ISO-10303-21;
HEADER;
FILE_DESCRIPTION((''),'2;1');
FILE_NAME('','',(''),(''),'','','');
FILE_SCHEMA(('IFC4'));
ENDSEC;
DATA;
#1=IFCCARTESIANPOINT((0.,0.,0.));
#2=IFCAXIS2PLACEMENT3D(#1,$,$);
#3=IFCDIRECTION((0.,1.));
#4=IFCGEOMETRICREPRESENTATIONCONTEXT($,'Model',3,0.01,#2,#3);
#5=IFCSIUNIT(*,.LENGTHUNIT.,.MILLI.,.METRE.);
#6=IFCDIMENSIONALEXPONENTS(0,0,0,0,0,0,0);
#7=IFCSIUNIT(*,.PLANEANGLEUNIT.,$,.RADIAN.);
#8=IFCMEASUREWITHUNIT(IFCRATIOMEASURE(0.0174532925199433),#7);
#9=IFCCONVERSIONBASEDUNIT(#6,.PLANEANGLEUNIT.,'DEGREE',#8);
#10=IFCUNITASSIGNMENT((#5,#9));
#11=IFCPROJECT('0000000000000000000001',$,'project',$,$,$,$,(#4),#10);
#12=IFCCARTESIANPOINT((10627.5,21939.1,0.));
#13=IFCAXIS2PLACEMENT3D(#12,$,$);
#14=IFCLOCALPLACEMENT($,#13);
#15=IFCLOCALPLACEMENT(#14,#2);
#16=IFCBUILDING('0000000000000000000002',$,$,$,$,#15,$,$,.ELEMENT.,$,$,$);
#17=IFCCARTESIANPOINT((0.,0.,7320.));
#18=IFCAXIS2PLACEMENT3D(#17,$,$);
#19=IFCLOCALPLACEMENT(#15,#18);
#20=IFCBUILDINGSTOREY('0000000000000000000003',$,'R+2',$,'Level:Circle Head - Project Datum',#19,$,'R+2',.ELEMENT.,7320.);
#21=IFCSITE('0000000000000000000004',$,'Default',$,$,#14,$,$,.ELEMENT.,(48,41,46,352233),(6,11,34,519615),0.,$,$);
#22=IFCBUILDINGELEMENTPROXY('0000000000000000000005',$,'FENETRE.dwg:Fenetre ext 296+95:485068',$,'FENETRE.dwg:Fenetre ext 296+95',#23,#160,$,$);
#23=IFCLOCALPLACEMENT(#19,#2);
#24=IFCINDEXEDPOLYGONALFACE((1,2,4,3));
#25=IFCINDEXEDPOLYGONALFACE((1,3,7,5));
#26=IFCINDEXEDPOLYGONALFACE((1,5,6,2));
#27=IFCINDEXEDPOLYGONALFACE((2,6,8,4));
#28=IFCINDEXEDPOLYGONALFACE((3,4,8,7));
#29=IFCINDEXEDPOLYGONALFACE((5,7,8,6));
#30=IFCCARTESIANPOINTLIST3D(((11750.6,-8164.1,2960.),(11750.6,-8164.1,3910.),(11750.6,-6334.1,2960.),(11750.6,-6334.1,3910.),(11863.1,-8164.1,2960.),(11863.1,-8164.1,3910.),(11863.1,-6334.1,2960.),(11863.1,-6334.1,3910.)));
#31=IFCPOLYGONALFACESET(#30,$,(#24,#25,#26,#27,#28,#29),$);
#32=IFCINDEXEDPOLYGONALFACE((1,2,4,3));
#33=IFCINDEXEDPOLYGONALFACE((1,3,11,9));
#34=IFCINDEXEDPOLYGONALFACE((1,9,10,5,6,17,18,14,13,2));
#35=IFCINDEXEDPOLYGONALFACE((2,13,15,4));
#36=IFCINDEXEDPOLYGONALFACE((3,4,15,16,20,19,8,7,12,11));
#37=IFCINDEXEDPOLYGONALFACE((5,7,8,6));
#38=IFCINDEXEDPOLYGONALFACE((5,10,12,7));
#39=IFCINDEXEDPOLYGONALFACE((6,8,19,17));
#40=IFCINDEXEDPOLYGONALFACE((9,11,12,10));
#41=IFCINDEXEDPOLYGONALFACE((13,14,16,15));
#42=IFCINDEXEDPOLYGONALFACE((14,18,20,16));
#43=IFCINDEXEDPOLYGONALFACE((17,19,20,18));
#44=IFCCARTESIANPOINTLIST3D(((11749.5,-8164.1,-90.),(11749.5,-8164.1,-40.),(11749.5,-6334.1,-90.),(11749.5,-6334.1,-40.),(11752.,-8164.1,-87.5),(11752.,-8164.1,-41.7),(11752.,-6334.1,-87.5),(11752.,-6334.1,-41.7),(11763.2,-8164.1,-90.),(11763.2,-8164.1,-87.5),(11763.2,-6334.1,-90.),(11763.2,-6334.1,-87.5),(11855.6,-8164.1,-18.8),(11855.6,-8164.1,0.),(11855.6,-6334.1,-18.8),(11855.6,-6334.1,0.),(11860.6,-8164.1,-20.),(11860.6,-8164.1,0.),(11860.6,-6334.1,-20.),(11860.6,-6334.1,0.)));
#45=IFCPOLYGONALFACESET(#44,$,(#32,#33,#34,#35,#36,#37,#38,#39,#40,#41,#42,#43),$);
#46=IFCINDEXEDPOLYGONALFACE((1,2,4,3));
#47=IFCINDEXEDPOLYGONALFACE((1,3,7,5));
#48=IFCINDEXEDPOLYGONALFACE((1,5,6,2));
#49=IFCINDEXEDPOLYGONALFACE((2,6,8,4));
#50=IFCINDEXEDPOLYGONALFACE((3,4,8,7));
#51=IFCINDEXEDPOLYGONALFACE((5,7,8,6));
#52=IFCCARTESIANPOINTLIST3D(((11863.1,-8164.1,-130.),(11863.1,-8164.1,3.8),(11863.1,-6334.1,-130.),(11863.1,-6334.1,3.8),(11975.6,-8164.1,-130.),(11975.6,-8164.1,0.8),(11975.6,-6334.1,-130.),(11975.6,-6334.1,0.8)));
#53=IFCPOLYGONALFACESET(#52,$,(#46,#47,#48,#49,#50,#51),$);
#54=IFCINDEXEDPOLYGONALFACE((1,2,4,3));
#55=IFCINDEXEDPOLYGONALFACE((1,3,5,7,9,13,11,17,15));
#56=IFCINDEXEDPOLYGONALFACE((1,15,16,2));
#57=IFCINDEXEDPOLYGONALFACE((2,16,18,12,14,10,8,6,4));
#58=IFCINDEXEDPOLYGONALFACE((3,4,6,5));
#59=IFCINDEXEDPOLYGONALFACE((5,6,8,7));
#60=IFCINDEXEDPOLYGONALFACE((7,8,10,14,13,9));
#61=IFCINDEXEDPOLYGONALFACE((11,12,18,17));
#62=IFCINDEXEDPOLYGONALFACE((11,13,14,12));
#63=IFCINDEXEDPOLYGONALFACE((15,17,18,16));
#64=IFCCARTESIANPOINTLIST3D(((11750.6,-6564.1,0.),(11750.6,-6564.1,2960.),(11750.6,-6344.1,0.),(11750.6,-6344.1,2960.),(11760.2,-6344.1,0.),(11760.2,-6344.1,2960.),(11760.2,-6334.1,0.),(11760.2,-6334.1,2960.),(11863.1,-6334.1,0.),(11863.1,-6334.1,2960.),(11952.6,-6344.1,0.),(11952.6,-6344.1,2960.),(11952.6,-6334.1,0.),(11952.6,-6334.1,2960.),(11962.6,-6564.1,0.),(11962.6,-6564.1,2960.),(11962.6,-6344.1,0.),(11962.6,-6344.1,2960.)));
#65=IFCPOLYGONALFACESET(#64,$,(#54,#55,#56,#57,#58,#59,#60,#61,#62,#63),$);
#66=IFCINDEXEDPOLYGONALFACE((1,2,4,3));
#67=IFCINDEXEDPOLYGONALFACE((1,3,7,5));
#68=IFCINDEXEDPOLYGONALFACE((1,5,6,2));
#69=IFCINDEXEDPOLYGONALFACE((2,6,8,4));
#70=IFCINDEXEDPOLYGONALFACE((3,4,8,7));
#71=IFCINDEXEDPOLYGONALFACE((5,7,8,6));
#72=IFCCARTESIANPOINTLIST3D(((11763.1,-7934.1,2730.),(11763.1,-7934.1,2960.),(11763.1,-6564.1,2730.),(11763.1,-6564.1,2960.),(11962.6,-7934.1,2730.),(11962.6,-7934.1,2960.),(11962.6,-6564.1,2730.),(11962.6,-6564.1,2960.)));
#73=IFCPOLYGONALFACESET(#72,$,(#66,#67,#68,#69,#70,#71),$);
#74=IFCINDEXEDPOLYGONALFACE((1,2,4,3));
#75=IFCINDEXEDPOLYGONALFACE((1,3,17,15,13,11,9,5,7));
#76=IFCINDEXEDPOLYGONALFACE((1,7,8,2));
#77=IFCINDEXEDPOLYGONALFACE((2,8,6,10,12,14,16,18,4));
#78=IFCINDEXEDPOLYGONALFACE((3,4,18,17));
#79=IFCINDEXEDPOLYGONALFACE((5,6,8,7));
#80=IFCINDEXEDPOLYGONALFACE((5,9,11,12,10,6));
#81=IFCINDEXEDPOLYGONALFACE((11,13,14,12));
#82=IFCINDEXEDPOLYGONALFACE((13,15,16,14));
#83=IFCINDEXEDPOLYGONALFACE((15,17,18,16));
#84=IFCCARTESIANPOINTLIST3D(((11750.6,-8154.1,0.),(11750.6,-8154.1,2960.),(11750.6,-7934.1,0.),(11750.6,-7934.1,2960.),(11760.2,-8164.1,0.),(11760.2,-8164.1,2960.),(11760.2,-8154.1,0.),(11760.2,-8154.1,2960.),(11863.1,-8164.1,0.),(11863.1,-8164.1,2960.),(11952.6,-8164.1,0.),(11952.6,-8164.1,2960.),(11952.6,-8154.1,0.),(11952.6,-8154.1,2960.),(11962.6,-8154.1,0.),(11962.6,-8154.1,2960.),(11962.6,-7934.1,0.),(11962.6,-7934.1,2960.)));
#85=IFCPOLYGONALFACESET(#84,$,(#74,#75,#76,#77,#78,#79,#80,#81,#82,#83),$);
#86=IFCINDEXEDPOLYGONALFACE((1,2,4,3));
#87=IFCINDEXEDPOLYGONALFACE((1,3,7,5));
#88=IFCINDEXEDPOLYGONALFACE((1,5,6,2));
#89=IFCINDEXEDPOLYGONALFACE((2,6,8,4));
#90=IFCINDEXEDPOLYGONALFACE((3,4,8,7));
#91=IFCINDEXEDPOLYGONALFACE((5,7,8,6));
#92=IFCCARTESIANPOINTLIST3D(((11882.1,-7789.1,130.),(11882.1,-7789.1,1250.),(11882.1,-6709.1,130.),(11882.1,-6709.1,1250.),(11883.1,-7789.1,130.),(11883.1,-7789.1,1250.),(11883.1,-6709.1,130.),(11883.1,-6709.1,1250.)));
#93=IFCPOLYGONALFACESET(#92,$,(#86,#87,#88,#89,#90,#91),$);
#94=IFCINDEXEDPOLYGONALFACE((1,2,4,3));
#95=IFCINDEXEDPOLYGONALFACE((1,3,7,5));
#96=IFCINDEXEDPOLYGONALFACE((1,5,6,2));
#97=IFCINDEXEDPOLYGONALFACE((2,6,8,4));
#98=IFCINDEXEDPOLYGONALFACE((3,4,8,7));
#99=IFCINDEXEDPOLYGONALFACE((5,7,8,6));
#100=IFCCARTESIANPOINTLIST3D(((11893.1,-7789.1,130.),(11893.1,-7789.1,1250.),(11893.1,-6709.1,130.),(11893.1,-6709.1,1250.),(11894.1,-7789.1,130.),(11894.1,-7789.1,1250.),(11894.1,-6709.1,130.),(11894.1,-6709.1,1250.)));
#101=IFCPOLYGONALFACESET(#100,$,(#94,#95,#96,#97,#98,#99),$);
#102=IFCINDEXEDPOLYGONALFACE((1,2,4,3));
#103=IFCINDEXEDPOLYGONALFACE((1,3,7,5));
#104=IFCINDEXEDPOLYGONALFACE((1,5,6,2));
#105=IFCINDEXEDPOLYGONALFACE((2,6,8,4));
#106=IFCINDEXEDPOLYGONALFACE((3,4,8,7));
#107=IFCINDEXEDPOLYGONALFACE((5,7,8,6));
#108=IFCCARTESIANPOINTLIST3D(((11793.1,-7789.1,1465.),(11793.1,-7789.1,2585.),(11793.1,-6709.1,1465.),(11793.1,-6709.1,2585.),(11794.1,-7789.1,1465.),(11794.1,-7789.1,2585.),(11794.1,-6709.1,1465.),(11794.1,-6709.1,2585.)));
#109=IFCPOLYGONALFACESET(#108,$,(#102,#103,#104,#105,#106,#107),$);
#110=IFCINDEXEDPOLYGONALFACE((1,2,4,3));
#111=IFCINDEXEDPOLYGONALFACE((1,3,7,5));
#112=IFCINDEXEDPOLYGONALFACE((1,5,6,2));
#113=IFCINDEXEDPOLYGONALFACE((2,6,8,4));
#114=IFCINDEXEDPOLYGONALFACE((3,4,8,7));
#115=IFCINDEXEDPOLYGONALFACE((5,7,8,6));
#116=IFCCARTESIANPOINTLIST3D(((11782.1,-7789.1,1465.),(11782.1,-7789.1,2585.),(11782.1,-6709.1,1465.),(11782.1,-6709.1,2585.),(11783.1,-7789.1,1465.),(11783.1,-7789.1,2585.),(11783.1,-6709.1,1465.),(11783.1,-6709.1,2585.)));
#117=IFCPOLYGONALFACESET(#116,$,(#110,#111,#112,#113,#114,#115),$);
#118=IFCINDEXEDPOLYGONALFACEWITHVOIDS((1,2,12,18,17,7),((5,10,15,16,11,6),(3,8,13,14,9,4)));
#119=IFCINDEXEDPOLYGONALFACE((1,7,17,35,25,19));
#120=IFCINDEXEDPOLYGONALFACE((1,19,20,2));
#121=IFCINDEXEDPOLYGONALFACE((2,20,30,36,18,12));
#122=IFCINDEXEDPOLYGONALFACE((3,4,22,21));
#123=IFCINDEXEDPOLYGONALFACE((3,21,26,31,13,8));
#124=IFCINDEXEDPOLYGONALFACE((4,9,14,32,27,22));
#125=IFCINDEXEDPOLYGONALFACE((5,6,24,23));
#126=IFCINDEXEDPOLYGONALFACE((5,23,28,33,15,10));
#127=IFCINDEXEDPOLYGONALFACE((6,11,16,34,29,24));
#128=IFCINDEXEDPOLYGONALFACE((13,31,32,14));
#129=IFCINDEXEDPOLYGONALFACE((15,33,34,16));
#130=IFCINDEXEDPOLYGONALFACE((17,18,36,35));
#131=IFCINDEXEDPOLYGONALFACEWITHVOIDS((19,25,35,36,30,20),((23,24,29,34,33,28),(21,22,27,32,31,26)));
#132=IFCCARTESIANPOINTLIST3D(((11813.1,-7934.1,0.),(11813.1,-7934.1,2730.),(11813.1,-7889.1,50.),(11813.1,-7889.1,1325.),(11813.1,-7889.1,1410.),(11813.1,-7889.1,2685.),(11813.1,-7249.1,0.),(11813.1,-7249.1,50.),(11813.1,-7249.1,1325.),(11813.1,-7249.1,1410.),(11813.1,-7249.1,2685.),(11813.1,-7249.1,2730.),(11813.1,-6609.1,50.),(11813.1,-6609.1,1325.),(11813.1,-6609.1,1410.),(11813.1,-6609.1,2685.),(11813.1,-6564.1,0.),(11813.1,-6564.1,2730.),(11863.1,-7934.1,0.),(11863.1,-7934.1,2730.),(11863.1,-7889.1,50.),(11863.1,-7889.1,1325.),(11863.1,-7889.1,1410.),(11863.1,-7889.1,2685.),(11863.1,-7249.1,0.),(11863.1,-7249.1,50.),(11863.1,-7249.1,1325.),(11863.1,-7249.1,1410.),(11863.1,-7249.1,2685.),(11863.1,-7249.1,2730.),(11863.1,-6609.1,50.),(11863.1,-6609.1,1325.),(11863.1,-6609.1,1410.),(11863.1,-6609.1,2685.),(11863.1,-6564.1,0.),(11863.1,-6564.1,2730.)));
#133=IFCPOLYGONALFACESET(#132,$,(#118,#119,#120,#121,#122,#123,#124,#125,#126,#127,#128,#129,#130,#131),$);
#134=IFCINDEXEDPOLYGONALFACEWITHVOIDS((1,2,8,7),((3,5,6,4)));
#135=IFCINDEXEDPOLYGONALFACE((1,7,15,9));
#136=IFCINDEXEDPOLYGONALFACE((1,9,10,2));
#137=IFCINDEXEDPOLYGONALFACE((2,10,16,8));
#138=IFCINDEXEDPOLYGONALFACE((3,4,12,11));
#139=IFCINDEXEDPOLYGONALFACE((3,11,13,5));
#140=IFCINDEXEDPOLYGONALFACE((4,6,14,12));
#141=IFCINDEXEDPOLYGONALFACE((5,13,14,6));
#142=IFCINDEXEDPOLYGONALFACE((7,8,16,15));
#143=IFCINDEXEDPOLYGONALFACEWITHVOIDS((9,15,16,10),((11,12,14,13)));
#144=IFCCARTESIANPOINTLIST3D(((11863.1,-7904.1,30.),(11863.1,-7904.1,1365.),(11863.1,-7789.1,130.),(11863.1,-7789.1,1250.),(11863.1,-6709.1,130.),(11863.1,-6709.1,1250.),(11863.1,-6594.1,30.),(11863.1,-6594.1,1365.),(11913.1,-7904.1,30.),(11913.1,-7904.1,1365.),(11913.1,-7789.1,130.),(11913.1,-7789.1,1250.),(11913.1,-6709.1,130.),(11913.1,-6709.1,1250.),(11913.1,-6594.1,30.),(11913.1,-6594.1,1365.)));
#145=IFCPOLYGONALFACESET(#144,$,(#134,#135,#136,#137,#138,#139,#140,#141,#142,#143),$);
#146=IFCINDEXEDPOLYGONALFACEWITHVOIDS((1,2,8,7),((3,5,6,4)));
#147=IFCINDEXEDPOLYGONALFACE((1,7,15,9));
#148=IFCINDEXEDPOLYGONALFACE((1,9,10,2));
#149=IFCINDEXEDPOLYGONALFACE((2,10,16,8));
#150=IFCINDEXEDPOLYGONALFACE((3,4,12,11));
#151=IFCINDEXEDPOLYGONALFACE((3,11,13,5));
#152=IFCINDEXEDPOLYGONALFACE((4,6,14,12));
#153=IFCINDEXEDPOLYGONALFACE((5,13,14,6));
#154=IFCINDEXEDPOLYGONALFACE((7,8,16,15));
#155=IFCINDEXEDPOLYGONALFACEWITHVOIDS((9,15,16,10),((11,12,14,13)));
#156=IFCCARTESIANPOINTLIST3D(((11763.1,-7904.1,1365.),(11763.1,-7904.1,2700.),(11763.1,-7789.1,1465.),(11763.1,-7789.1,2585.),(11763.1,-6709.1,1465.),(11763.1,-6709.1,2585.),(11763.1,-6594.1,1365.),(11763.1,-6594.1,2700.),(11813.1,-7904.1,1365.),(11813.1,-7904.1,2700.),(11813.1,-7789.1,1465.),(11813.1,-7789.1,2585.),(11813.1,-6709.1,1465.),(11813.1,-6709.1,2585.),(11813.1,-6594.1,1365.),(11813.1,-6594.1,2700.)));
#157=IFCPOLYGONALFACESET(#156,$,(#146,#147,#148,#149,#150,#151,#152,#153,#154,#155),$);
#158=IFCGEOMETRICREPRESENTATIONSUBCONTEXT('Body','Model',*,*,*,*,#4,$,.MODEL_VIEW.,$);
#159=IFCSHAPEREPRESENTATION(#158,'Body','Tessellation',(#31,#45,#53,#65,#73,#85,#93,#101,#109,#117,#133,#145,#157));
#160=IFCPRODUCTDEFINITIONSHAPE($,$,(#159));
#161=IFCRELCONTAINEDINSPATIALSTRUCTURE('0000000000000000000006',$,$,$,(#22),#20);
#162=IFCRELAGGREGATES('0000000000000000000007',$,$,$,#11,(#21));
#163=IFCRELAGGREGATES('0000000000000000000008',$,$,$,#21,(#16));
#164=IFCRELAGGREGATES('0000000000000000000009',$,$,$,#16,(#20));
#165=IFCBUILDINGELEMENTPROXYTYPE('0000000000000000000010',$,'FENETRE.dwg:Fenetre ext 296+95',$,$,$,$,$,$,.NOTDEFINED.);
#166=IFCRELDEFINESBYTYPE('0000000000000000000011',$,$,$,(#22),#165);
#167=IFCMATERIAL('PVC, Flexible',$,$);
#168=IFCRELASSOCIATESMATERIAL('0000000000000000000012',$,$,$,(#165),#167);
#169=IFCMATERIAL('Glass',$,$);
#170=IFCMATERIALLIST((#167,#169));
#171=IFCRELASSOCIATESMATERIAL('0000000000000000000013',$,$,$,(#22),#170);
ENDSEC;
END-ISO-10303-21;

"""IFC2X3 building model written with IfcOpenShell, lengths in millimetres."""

from ifc_helpers import new_model, entity, si_unit, converted_unit, direction, frame, frame_2d, origin, origin_2d_with_axis, place, context, subcontext, project, spatial, polyline, rectangle, outline, extrude, source, transform, mapped, material, material_list, type_object, type_shapes, element, save


model = new_model("IFC2X3")

# Units and contexts
model_context = context("Model", 3, precision=0.01, world=origin(), true_north=direction((0.0, 1.0)))
body_context = subcontext(model_context, "Body", "Model", "MODEL_VIEW")
ifc_project = project(units=[si_unit("LENGTHUNIT", "METRE", prefix="MILLI"), converted_unit("PLANEANGLEUNIT", "DEGREE", entity("IfcRatioMeasure", 0.0174532925199433), si_unit("PLANEANGLEUNIT", "RADIAN"), dimensions=[0, 0, 0, 0, 0, 0, 0])], contexts=[model_context])

# Site, building, storey
site_placement = place(None, frame((10627.5, 21939.1, 0.0)))
site = spatial("IfcSite", under=ifc_project, at=site_placement, Name="Default", CompositionType="ELEMENT", RefLatitude=(48, 41, 46, 352233), RefLongitude=(6, 11, 34, 519615), RefElevation=0.0)
building_placement = place(site_placement, origin())
building = spatial("IfcBuilding", under=site, at=building_placement, CompositionType="ELEMENT")
storey_placement = place(building_placement, frame((0.0, 0.0, 7320.0)))
storey = spatial("IfcBuildingStorey", under=building, at=storey_placement, Name="R+2", ObjectType="Level:Circle Head - Project Datum", LongName="R+2", CompositionType="ELEMENT", Elevation=7320.0)

# Building element proxy
ifc_material_1 = material(Name="PVC, Flexible")
ifc_material_2 = material(Name="Glass")
building_element_proxy_type_1 = type_object("IfcBuildingElementProxyType", Name="FENETRE.dwg:Fenetre ext 296+95", PredefinedType="NOTDEFINED", material=ifc_material_1)
shared_shape_1 = source(origin(), body_context, "Body", "SweptSolid", [
    extrude(rectangle(XDim=1830.0, YDim=112.5, at=origin_2d_with_axis()), frame((-10.4, 56.3, 2960.0), z_axis=(0.0, 0.0, 1.0), x_axis=(-1.0, 0.0, 0.0)), (0.0, 0.0, 1.0), 950.0),
    extrude(outline(polyline([(-68.6, -14.4), (-72.5, -34.0), (-67.6, -35.0), (-63.9, -16.6), (44.3, -16.6), (54.1, 32.5), (40.6, 35.2), (40.1, 32.7), (51.2, 30.5), (42.2, -14.4), (-68.6, -14.4)])), frame((-925.4, 66.9, -47.5), z_axis=(-1.0, 0.0, 0.0), x_axis=(0.0, 0.980599, -0.196027)), (0.0, 0.0, -1.0), 1830.0),
    extrude(outline(polyline([(-64.7, -56.3), (66.2, -56.3), (66.2, 56.3), (-67.7, 56.3), (-64.7, -56.3)])), frame((-925.4, -56.3, -63.8), z_axis=(1.0, 0.0, 0.0), x_axis=(0.0, 0.0, -1.0)), (0.0, 0.0, 1.0), 1830.0),
    extrude(outline(polyline([(-55.6, 97.0), (-55.6, -5.9), (-55.6, -95.4), (-45.6, -95.4), (-45.6, -105.4), (174.4, -105.4), (174.4, 106.6), (-45.6, 106.6), (-45.6, 97.0), (-55.6, 97.0)])), frame((849.0, 5.9, 0.0), z_axis=(0.0, 0.0, -1.0), x_axis=(-1.0, 0.0, 0.0)), (0.0, 0.0, -1.0), 2960.0),
    extrude(rectangle(XDim=199.5, YDim=1370.0, at=origin_2d_with_axis()), frame((-10.4, 0.3, 2730.0), z_axis=(0.0, 0.0, 1.0), x_axis=(0.0, 1.0, 0.0)), (0.0, 0.0, 1.0), 230.0),
    extrude(outline(polyline([(-97.0, -55.6), (5.9, -55.6), (95.4, -55.6), (95.4, -45.6), (105.4, -45.6), (105.4, 174.4), (-106.6, 174.4), (-106.6, -45.6), (-97.0, -45.6), (-97.0, -55.6)])), frame((-869.9, 5.9, 0.0), z_axis=(0.0, 0.0, 1.0), x_axis=(0.0, -1.0, 0.0)), (0.0, 0.0, 1.0), 2960.0),
    extrude(rectangle(XDim=1.0, YDim=1080.0, at=origin_2d_with_axis()), frame((-10.4, -19.5, 130.0), z_axis=(0.0, 0.0, 1.0), x_axis=(0.0, 1.0, 0.0)), (0.0, 0.0, 1.0), 1120.0),
    extrude(rectangle(XDim=1.0, YDim=1080.0, at=frame_2d((0.0, 0.0), x_axis=(1.0, 0.0))), frame((-10.4, -30.5, 130.0), z_axis=(0.0, 0.0, 1.0), x_axis=(0.0, 1.0, 0.0)), (0.0, 0.0, 1.0), 1120.0),
    extrude(rectangle(XDim=1.0, YDim=1080.0, at=frame_2d((0.0, 0.0), x_axis=(1.0, 0.0))), frame((-10.4, 69.5, 1465.0), z_axis=(0.0, 0.0, 1.0), x_axis=(0.0, 1.0, 0.0)), (0.0, 0.0, 1.0), 1120.0),
    extrude(rectangle(XDim=1.0, YDim=1080.0, at=frame_2d((0.0, 0.0), x_axis=(1.0, 0.0))), frame((-10.4, 80.5, 1465.0), z_axis=(0.0, 0.0, 1.0), x_axis=(0.0, 1.0, 0.0)), (0.0, 0.0, 1.0), 1120.0),
    extrude(outline(polyline([(-685.0, -1365.0), (0.0, -1365.0), (685.0, -1365.0), (685.0, 1365.0), (0.0, 1365.0), (-685.0, 1365.0), (-685.0, -1365.0)]), holes=[polyline([(-640.0, -1320.0), (-640.0, -45.0), (0.0, -45.0), (640.0, -45.0), (640.0, -1320.0), (0.0, -1320.0), (-640.0, -1320.0)]), polyline([(-640.0, 40.0), (-640.0, 1315.0), (0.0, 1315.0), (640.0, 1315.0), (640.0, 40.0), (0.0, 40.0), (-640.0, 40.0)])]), frame((-10.4, 0.0, 1365.0), z_axis=(0.0, 1.0, 0.0), x_axis=(1.0, 0.0, 0.0)), (0.0, 0.0, 1.0), 50.0),
    extrude(outline(polyline([(-655.0, -667.5), (655.0, -667.5), (655.0, 667.5), (-655.0, 667.5), (-655.0, -667.5)]), holes=[polyline([(-540.0, 552.5), (540.0, 552.5), (540.0, -567.5), (-540.0, -567.5), (-540.0, 552.5)])]), frame((-10.4, -50.0, 697.5), z_axis=(0.0, 1.0, 0.0), x_axis=(-1.0, 0.0, 0.0)), (0.0, 0.0, 1.0), 50.0),
    extrude(outline(polyline([(-655.0, -667.5), (655.0, -667.5), (655.0, 667.5), (-655.0, 667.5), (-655.0, -667.5)]), holes=[polyline([(-540.0, 552.5), (540.0, 552.5), (540.0, -567.5), (-540.0, -567.5), (-540.0, 552.5)])]), frame((-10.4, 50.0, 2032.5), z_axis=(0.0, 1.0, 0.0), x_axis=(-1.0, 0.0, 0.0)), (0.0, 0.0, 1.0), 50.0),
])
type_shapes(building_element_proxy_type_1, [shared_shape_1])
ifc_material_list_1 = material_list([ifc_material_1, ifc_material_2])
proxy_1_placement = place(storey_placement, frame((11863.1, -7238.7, 0.0), z_axis=(0.0, 0.0, 1.0), x_axis=(0.0, 1.0, 0.0)))
element("IfcBuildingElementProxy", 1, at=proxy_1_placement, inside=storey, type_object=building_element_proxy_type_1, material=ifc_material_list_1, Name="FENETRE.dwg:Fenetre ext 296+95:485068", ObjectType="FENETRE.dwg:Fenetre ext 296+95", context=body_context, shape_type="MappedRepresentation", body=[
    mapped(shared_shape_1, transform((0.0, 0.0, 0.0), scale=1.0)),
])

save(model, "model.ifc")
